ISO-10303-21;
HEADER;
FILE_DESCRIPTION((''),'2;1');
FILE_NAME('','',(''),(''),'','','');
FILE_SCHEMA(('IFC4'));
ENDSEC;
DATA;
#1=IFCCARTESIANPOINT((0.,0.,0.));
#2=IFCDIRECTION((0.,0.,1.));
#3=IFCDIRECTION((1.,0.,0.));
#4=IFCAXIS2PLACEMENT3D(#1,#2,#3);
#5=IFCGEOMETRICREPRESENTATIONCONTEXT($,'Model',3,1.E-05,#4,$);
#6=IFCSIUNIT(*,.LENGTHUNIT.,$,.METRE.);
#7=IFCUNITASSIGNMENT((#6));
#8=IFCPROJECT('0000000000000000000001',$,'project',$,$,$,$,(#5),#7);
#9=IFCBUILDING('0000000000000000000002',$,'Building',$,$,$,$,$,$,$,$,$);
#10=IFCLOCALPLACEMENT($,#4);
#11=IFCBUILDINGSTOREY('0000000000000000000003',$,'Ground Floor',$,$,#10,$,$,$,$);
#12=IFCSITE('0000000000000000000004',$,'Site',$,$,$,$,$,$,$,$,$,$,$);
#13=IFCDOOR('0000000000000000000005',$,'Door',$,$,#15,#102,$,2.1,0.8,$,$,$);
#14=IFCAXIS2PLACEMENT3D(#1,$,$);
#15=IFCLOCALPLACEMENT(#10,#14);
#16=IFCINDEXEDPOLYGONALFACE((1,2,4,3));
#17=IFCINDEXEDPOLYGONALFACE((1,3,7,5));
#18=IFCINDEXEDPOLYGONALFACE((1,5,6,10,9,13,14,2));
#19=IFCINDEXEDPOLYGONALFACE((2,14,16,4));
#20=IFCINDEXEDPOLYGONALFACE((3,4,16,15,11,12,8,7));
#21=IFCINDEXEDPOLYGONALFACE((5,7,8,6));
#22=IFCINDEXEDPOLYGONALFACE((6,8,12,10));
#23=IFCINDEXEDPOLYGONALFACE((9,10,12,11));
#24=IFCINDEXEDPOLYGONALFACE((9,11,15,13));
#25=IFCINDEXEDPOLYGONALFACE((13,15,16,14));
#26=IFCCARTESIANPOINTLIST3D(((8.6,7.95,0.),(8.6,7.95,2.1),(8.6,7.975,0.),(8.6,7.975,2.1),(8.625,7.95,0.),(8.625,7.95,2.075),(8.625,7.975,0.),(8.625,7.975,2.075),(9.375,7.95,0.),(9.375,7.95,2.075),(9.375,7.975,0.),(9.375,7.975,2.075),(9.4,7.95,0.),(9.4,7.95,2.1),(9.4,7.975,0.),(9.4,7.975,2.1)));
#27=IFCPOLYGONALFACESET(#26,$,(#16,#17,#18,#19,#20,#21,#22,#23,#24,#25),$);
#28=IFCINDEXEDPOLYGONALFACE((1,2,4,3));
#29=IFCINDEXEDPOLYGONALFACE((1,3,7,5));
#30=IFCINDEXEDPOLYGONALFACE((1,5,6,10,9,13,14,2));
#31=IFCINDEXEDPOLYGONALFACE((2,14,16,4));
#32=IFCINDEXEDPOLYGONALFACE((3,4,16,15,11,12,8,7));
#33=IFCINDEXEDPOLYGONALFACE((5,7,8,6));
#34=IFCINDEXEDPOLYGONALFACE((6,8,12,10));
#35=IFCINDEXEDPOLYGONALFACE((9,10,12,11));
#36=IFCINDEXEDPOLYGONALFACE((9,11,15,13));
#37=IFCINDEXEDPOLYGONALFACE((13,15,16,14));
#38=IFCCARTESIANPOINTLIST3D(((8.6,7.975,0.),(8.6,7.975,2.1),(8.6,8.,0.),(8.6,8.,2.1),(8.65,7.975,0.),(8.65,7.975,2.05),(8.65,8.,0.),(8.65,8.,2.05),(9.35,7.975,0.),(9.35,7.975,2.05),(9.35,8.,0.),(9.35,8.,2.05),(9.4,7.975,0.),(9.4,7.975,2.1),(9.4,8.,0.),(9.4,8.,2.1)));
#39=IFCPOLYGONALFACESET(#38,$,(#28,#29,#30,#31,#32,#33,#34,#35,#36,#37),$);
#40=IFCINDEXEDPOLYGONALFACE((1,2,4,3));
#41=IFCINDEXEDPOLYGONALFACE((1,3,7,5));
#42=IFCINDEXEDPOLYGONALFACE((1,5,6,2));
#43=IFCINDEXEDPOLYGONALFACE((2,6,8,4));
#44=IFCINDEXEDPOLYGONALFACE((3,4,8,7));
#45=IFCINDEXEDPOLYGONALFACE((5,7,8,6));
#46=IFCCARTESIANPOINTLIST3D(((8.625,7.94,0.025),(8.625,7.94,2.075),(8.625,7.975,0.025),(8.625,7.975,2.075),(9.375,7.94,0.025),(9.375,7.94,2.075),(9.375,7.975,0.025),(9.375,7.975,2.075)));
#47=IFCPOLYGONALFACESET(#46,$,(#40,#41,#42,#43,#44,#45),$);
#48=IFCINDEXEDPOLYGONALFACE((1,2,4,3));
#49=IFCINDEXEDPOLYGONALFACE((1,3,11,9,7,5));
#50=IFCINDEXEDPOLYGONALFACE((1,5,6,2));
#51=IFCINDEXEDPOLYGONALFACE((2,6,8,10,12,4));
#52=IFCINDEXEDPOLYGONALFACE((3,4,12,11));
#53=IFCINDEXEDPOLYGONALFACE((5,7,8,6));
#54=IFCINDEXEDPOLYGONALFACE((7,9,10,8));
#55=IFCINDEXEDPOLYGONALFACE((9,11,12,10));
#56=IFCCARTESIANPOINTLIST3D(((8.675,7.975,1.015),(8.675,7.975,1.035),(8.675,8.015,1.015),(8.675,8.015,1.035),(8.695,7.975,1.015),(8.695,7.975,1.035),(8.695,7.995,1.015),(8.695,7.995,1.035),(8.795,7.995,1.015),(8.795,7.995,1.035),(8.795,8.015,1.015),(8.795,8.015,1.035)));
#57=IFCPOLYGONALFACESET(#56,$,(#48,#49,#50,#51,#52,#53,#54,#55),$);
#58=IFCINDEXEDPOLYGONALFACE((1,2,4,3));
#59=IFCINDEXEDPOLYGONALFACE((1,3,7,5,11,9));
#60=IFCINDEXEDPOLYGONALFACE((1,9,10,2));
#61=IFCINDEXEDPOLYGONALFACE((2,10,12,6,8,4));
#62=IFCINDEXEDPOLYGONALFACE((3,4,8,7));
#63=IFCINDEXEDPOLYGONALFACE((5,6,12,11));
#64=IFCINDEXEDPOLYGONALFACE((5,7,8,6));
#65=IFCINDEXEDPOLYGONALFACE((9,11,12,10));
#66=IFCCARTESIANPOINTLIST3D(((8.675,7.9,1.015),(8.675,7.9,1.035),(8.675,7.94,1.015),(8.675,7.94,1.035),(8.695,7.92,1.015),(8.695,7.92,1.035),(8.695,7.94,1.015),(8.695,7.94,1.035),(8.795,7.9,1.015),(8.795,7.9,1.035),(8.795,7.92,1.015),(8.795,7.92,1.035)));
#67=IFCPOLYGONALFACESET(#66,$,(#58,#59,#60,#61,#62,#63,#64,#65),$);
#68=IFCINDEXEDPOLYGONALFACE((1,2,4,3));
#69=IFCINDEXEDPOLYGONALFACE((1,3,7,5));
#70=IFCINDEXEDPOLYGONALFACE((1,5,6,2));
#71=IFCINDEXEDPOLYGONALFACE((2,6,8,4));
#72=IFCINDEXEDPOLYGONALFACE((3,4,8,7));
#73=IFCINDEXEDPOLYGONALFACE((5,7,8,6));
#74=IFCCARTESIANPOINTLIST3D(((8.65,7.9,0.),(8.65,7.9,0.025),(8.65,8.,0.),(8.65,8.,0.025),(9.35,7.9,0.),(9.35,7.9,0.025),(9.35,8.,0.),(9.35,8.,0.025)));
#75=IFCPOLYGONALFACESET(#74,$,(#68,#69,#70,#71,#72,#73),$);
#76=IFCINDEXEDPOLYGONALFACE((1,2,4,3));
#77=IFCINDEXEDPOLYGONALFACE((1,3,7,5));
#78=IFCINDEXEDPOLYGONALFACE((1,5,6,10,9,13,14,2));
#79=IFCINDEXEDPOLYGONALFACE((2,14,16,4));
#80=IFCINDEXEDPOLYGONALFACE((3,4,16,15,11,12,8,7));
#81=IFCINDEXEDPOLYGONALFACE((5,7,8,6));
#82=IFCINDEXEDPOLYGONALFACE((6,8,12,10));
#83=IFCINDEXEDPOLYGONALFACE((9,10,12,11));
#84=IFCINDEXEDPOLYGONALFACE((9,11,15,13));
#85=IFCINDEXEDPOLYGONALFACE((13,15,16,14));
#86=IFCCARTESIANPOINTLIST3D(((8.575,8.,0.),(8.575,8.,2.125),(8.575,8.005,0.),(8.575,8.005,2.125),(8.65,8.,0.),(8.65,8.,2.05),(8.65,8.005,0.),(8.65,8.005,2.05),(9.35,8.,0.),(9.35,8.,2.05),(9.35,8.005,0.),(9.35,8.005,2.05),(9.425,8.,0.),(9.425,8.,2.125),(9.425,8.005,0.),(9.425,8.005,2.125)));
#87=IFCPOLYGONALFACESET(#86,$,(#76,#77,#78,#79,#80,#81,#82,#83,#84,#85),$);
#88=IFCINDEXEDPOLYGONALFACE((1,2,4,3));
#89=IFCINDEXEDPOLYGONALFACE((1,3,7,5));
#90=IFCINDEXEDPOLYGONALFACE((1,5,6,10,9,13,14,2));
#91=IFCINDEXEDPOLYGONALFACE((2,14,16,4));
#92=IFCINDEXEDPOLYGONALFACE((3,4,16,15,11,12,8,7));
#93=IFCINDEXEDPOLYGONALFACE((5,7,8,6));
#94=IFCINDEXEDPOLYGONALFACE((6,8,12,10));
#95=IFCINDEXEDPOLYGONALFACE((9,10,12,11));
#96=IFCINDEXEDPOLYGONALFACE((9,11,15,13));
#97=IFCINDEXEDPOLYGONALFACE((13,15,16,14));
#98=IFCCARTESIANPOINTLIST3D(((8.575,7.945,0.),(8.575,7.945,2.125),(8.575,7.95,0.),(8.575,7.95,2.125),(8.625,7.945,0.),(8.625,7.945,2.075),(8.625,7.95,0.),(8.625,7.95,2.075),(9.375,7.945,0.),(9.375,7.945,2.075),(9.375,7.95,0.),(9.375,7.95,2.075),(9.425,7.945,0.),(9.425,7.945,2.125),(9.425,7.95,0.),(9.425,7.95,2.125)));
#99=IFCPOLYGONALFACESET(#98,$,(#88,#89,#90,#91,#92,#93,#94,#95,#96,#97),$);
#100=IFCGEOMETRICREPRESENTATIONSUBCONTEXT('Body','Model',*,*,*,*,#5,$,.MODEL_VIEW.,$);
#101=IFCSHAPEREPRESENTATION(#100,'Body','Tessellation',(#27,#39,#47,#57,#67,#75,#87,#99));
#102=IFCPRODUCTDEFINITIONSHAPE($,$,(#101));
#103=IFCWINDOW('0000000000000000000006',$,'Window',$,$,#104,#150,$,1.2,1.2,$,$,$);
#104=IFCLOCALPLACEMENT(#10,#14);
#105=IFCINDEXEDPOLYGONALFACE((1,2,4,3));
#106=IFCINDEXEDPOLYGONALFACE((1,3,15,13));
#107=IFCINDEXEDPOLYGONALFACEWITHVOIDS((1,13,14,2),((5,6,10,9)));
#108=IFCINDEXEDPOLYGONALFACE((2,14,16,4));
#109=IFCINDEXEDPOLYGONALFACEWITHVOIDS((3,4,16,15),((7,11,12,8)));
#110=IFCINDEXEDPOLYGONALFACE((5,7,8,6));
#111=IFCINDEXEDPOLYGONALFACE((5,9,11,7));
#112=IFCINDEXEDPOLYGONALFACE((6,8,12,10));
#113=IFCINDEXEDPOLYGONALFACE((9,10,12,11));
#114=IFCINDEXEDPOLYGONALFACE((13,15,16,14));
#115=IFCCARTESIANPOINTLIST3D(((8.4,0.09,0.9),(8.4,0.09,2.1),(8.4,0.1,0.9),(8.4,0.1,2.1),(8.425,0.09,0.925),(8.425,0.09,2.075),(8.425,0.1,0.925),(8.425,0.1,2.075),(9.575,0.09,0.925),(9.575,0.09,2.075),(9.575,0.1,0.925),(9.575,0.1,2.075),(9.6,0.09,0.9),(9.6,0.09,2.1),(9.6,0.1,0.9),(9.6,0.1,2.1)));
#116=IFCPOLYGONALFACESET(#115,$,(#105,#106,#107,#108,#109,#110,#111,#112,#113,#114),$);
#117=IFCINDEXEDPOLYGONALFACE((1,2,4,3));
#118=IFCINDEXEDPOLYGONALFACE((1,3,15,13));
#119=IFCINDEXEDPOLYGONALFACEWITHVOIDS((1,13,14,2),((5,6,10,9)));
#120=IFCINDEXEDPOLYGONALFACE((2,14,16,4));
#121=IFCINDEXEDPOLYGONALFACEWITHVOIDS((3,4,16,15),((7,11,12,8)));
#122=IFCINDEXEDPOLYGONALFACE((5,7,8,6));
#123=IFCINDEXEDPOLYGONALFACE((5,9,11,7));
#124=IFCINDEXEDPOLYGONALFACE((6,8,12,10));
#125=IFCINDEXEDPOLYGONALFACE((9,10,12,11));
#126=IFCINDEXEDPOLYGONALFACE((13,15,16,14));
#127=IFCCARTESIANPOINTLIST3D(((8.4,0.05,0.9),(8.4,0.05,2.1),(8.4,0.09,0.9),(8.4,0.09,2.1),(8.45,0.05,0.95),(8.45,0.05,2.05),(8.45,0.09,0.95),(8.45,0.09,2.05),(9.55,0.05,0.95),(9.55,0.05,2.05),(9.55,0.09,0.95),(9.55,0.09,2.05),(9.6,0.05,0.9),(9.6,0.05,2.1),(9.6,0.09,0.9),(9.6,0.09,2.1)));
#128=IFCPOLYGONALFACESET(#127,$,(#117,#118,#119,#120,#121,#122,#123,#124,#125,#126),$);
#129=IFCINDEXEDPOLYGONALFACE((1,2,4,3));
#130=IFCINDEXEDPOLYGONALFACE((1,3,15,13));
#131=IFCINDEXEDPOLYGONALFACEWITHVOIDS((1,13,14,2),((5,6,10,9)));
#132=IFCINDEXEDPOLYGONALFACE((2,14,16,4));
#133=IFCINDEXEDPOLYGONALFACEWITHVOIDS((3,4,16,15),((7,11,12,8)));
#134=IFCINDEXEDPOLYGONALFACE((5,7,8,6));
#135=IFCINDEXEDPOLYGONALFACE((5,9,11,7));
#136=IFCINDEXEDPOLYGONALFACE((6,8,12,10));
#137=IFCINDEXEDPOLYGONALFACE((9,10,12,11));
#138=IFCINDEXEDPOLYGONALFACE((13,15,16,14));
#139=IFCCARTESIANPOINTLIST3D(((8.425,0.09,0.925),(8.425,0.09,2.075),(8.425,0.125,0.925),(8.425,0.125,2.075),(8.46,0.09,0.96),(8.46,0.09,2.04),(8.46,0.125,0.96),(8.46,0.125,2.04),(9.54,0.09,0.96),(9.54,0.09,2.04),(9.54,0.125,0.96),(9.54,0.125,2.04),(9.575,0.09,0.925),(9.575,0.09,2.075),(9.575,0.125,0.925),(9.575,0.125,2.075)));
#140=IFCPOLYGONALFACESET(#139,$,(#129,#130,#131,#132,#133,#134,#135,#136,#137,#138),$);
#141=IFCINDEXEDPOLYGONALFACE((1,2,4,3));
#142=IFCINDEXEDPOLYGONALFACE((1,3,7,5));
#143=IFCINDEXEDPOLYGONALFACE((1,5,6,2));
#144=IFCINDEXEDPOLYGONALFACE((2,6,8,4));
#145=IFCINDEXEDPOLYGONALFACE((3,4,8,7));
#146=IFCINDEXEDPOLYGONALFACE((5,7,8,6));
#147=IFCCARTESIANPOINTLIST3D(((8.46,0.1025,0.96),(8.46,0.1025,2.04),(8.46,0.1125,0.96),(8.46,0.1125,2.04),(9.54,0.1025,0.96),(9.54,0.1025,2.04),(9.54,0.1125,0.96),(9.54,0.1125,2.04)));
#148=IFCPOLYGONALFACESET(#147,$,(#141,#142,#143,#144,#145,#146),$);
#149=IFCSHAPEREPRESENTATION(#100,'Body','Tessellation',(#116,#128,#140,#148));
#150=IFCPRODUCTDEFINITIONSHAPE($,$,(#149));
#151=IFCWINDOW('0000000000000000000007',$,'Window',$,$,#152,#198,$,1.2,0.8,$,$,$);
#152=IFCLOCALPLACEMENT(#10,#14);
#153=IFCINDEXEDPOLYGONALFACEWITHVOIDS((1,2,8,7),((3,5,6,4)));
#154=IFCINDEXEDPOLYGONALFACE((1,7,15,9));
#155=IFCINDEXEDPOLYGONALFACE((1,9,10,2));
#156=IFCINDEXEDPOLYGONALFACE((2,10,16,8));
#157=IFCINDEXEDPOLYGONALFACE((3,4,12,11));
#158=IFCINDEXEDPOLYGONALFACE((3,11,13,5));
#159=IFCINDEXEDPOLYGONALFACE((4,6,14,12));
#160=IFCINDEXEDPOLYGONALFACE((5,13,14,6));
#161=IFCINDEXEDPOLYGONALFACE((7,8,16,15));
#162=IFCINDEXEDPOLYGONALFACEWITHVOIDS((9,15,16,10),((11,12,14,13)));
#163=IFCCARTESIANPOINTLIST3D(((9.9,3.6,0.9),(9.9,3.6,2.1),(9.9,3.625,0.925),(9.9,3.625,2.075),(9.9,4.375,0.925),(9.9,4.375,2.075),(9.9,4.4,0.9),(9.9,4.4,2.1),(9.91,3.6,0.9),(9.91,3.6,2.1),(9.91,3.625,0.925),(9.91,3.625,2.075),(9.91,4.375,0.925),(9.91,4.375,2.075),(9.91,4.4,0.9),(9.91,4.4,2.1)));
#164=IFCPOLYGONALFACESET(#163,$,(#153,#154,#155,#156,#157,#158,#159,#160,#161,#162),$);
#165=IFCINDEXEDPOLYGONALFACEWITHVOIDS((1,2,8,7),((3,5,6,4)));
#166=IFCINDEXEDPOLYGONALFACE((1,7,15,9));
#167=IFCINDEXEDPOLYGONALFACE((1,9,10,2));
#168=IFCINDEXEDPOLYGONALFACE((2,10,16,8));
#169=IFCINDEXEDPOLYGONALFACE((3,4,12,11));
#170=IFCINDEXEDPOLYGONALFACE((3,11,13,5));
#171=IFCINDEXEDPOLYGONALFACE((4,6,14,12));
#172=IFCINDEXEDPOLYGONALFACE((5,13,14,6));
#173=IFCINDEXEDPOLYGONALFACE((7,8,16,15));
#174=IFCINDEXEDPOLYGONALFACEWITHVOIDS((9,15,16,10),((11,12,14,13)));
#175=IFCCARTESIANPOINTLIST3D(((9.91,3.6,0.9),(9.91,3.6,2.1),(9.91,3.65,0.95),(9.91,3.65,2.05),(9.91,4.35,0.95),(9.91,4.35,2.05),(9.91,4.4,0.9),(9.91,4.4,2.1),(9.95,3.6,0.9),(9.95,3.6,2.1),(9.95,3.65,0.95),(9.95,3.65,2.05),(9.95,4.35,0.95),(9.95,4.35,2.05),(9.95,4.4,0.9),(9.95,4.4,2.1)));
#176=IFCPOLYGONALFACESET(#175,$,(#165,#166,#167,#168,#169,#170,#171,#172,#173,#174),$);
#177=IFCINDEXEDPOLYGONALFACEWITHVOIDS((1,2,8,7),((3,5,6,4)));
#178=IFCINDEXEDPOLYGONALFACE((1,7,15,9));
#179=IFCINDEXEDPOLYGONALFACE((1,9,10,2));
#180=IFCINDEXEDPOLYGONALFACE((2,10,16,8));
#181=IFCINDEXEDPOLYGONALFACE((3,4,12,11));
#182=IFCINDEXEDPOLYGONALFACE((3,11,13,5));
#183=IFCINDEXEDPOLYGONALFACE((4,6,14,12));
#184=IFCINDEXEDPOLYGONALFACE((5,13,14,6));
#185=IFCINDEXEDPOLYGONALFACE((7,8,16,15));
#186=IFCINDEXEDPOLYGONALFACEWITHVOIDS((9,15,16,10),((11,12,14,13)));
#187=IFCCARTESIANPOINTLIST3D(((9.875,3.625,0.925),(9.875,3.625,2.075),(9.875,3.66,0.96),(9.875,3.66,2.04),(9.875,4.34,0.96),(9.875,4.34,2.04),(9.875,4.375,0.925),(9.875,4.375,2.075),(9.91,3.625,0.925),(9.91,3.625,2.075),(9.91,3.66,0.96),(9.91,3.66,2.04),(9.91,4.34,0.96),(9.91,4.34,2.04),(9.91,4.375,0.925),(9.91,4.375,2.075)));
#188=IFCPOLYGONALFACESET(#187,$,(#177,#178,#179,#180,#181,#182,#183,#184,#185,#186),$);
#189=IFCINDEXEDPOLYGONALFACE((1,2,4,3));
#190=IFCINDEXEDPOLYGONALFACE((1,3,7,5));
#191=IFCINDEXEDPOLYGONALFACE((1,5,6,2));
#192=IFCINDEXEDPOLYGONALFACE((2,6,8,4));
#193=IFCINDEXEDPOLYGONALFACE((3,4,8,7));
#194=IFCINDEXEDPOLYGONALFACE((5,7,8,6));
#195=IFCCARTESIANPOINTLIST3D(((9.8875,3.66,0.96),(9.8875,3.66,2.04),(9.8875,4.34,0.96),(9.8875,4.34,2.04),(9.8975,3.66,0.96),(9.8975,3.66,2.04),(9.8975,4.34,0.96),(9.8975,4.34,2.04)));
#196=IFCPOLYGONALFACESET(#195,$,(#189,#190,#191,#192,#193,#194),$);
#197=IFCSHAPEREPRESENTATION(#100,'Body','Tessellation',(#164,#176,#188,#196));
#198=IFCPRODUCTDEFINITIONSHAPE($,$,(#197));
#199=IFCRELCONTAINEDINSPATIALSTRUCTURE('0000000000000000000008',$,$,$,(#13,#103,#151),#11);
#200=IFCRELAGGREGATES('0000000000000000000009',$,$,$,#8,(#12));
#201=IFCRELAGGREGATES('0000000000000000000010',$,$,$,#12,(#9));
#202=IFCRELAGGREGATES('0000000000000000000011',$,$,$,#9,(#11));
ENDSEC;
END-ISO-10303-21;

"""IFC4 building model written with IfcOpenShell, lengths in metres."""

from ifc_helpers import new_model, si_unit, frame, origin_with_axes, place, context, subcontext, project, spatial, line, indexed_curve, outline, extrude, element, save


model = new_model("IFC4")

# Units and contexts
model_context = context("Model", 3, precision=1e-05, world=origin_with_axes())
body_context = subcontext(model_context, "Body", "Model", "MODEL_VIEW")
ifc_project = project(units=[si_unit("LENGTHUNIT", "METRE")], contexts=[model_context])

# Site, building, storey
site = spatial("IfcSite", under=ifc_project, Name="Site")
building = spatial("IfcBuilding", under=site, Name="Building")
storey_placement = place(None, origin_with_axes())
storey = spatial("IfcBuildingStorey", under=building, at=storey_placement, Name="Ground Floor")

# Door
door_1_placement = place(storey_placement, frame((9.4, 8.0, 0.0), z_axis=(0.0, 0.0, 1.0), x_axis=(-1.0, 0.0, 0.0)))
element("IfcDoor", 1, at=door_1_placement, inside=storey, Name="Door", OverallHeight=2.1, OverallWidth=0.8, context=body_context, shape_type="SweptSolid", body=[
    extrude(outline(indexed_curve([(0.0, 0.0), (0.0, 2.1), (0.8, 2.1), (0.8, 0.0), (0.775, 0.0), (0.775, 2.075), (0.025, 2.075), (0.025, 0.0)], segments=[line(1, 2, 3, 4, 5, 6, 7, 8, 1)])), frame((0.0, 0.025, 0.0), z_axis=(0.0, -1.0, 0.0), x_axis=(1.0, 0.0, 0.0)), (0.0, 0.0, -1.0), 0.025),
    extrude(outline(indexed_curve([(0.0, 0.0), (0.0, 2.1), (0.8, 2.1), (0.8, 0.0), (0.75, 0.0), (0.75, 2.05), (0.05, 2.05), (0.05, 0.0)], segments=[line(1, 2, 3, 4, 5, 6, 7, 8, 1)])), frame((0.0, 0.0, 0.0), z_axis=(0.0, -1.0, 0.0), x_axis=(1.0, 0.0, 0.0)), (0.0, 0.0, -1.0), 0.025),
    extrude(outline(indexed_curve([(0.0, 0.0), (0.75, 0.0), (0.75, 0.035), (0.0, 0.035)], segments=[line(1, 2, 3, 4, 1)])), frame((0.025, 0.025, 0.025), z_axis=(0.0, 0.0, 1.0), x_axis=(1.0, 0.0, 0.0)), (0.0, 0.0, 1.0), 2.05),
    extrude(outline(indexed_curve([(0.0, 0.0), (0.0, -0.04), (-0.12, -0.04), (-0.12, -0.02), (-0.02, -0.02), (-0.02, 0.0)], segments=[line(1, 2, 3, 4, 5, 6, 1)])), frame((0.725, 0.025, 1.015), z_axis=(0.0, 0.0, 1.0), x_axis=(1.0, 0.0, 0.0)), (0.0, 0.0, 1.0), 0.02),
    extrude(outline(indexed_curve([(0.0, 0.0), (0.0, 0.04), (-0.12, 0.04), (-0.12, 0.02), (-0.02, 0.02), (-0.02, 0.0)], segments=[line(1, 2, 3, 4, 5, 6, 1)])), frame((0.725, 0.06, 1.015), z_axis=(0.0, 0.0, 1.0), x_axis=(1.0, 0.0, 0.0)), (0.0, 0.0, 1.0), 0.02),
    extrude(outline(indexed_curve([(0.0, 0.0), (0.7, 0.0), (0.7, 0.1), (0.0, 0.1)], segments=[line(1, 2, 3, 4, 1)])), frame((0.05, 0.0, 0.0), z_axis=(0.0, 0.0, 1.0), x_axis=(1.0, 0.0, 0.0)), (0.0, 0.0, 1.0), 0.025),
    extrude(outline(indexed_curve([(0.0, 0.0), (0.0, 2.125), (0.85, 2.125), (0.85, 0.0), (0.775, 0.0), (0.775, 2.05), (0.075, 2.05), (0.075, 0.0)], segments=[line(1, 2, 3, 4, 5, 6, 7, 8, 1)])), frame((-0.025, -0.005, 0.0), z_axis=(0.0, -1.0, 0.0), x_axis=(1.0, 0.0, 0.0)), (0.0, 0.0, -1.0), 0.005),
    extrude(outline(indexed_curve([(0.0, 0.0), (0.0, 2.125), (0.85, 2.125), (0.85, 0.0), (0.8, 0.0), (0.8, 2.075), (0.05, 2.075), (0.05, 0.0)], segments=[line(1, 2, 3, 4, 5, 6, 7, 8, 1)])), frame((-0.025, 0.05, 0.0), z_axis=(0.0, -1.0, 0.0), x_axis=(1.0, 0.0, 0.0)), (0.0, 0.0, -1.0), 0.005),
])

# Windows
window_1_placement = place(storey_placement, frame((8.4, 0.0, 0.9), z_axis=(0.0, 0.0, 1.0), x_axis=(1.0, 0.0, 0.0)))
element("IfcWindow", 2, at=window_1_placement, inside=storey, Name="Window", OverallHeight=1.2, OverallWidth=1.2, context=body_context, shape_type="SweptSolid", body=[
    extrude(outline(indexed_curve([(0.0, 0.0), (1.2, 0.0), (1.2, 1.2), (0.0, 1.2)], segments=[line(1, 2, 3, 4, 1)]), holes=[indexed_curve([(0.025, 0.025), (1.175, 0.025), (1.175, 1.175), (0.025, 1.175)], segments=[line(1, 2, 3, 4, 1)])]), frame((0.0, 0.09, 0.0), z_axis=(0.0, -1.0, 0.0), x_axis=(1.0, 0.0, 0.0)), (0.0, 0.0, -1.0), 0.01),
    extrude(outline(indexed_curve([(0.0, 0.0), (1.2, 0.0), (1.2, 1.2), (0.0, 1.2)], segments=[line(1, 2, 3, 4, 1)]), holes=[indexed_curve([(0.05, 0.05), (1.15, 0.05), (1.15, 1.15), (0.05, 1.15)], segments=[line(1, 2, 3, 4, 1)])]), frame((0.0, 0.05, 0.0), z_axis=(0.0, -1.0, 0.0), x_axis=(1.0, 0.0, 0.0)), (0.0, 0.0, -1.0), 0.04),
    extrude(outline(indexed_curve([(0.0, 0.0), (1.15, 0.0), (1.15, 1.15), (0.0, 1.15)], segments=[line(1, 2, 3, 4, 1)]), holes=[indexed_curve([(0.035, 0.035), (1.115, 0.035), (1.115, 1.115), (0.035, 1.115)], segments=[line(1, 2, 3, 4, 1)])]), frame((0.025, 0.09, 0.025), z_axis=(0.0, -1.0, 0.0), x_axis=(1.0, 0.0, 0.0)), (0.0, 0.0, -1.0), 0.035),
    extrude(outline(indexed_curve([(0.035, 0.035), (1.115, 0.035), (1.115, 1.115), (0.035, 1.115)], segments=[line(1, 2, 3, 4, 1)])), frame((0.025, 0.1025, 0.025), z_axis=(0.0, -1.0, 0.0), x_axis=(1.0, 0.0, 0.0)), (0.0, 0.0, -1.0), 0.01),
])
window_2_placement = place(storey_placement, frame((10.0, 3.6, 0.9), z_axis=(0.0, 0.0, 1.0), x_axis=(0.0, 1.0, 0.0)))
element("IfcWindow", 3, at=window_2_placement, inside=storey, Name="Window", OverallHeight=1.2, OverallWidth=0.8, context=body_context, shape_type="SweptSolid", body=[
    extrude(outline(indexed_curve([(0.0, 0.0), (0.8, 0.0), (0.8, 1.2), (0.0, 1.2)], segments=[line(1, 2, 3, 4, 1)]), holes=[indexed_curve([(0.025, 0.025), (0.775, 0.025), (0.775, 1.175), (0.025, 1.175)], segments=[line(1, 2, 3, 4, 1)])]), frame((0.0, 0.09, 0.0), z_axis=(0.0, -1.0, 0.0), x_axis=(1.0, 0.0, 0.0)), (0.0, 0.0, -1.0), 0.01),
    extrude(outline(indexed_curve([(0.0, 0.0), (0.8, 0.0), (0.8, 1.2), (0.0, 1.2)], segments=[line(1, 2, 3, 4, 1)]), holes=[indexed_curve([(0.05, 0.05), (0.75, 0.05), (0.75, 1.15), (0.05, 1.15)], segments=[line(1, 2, 3, 4, 1)])]), frame((0.0, 0.05, 0.0), z_axis=(0.0, -1.0, 0.0), x_axis=(1.0, 0.0, 0.0)), (0.0, 0.0, -1.0), 0.04),
    extrude(outline(indexed_curve([(0.0, 0.0), (0.75, 0.0), (0.75, 1.15), (0.0, 1.15)], segments=[line(1, 2, 3, 4, 1)]), holes=[indexed_curve([(0.035, 0.035), (0.715, 0.035), (0.715, 1.115), (0.035, 1.115)], segments=[line(1, 2, 3, 4, 1)])]), frame((0.025, 0.09, 0.025), z_axis=(0.0, -1.0, 0.0), x_axis=(1.0, 0.0, 0.0)), (0.0, 0.0, -1.0), 0.035),
    extrude(outline(indexed_curve([(0.035, 0.035), (0.715, 0.035), (0.715, 1.115), (0.035, 1.115)], segments=[line(1, 2, 3, 4, 1)])), frame((0.025, 0.1025, 0.025), z_axis=(0.0, -1.0, 0.0), x_axis=(1.0, 0.0, 0.0)), (0.0, 0.0, -1.0), 0.01),
])

save(model, "model.ifc")
